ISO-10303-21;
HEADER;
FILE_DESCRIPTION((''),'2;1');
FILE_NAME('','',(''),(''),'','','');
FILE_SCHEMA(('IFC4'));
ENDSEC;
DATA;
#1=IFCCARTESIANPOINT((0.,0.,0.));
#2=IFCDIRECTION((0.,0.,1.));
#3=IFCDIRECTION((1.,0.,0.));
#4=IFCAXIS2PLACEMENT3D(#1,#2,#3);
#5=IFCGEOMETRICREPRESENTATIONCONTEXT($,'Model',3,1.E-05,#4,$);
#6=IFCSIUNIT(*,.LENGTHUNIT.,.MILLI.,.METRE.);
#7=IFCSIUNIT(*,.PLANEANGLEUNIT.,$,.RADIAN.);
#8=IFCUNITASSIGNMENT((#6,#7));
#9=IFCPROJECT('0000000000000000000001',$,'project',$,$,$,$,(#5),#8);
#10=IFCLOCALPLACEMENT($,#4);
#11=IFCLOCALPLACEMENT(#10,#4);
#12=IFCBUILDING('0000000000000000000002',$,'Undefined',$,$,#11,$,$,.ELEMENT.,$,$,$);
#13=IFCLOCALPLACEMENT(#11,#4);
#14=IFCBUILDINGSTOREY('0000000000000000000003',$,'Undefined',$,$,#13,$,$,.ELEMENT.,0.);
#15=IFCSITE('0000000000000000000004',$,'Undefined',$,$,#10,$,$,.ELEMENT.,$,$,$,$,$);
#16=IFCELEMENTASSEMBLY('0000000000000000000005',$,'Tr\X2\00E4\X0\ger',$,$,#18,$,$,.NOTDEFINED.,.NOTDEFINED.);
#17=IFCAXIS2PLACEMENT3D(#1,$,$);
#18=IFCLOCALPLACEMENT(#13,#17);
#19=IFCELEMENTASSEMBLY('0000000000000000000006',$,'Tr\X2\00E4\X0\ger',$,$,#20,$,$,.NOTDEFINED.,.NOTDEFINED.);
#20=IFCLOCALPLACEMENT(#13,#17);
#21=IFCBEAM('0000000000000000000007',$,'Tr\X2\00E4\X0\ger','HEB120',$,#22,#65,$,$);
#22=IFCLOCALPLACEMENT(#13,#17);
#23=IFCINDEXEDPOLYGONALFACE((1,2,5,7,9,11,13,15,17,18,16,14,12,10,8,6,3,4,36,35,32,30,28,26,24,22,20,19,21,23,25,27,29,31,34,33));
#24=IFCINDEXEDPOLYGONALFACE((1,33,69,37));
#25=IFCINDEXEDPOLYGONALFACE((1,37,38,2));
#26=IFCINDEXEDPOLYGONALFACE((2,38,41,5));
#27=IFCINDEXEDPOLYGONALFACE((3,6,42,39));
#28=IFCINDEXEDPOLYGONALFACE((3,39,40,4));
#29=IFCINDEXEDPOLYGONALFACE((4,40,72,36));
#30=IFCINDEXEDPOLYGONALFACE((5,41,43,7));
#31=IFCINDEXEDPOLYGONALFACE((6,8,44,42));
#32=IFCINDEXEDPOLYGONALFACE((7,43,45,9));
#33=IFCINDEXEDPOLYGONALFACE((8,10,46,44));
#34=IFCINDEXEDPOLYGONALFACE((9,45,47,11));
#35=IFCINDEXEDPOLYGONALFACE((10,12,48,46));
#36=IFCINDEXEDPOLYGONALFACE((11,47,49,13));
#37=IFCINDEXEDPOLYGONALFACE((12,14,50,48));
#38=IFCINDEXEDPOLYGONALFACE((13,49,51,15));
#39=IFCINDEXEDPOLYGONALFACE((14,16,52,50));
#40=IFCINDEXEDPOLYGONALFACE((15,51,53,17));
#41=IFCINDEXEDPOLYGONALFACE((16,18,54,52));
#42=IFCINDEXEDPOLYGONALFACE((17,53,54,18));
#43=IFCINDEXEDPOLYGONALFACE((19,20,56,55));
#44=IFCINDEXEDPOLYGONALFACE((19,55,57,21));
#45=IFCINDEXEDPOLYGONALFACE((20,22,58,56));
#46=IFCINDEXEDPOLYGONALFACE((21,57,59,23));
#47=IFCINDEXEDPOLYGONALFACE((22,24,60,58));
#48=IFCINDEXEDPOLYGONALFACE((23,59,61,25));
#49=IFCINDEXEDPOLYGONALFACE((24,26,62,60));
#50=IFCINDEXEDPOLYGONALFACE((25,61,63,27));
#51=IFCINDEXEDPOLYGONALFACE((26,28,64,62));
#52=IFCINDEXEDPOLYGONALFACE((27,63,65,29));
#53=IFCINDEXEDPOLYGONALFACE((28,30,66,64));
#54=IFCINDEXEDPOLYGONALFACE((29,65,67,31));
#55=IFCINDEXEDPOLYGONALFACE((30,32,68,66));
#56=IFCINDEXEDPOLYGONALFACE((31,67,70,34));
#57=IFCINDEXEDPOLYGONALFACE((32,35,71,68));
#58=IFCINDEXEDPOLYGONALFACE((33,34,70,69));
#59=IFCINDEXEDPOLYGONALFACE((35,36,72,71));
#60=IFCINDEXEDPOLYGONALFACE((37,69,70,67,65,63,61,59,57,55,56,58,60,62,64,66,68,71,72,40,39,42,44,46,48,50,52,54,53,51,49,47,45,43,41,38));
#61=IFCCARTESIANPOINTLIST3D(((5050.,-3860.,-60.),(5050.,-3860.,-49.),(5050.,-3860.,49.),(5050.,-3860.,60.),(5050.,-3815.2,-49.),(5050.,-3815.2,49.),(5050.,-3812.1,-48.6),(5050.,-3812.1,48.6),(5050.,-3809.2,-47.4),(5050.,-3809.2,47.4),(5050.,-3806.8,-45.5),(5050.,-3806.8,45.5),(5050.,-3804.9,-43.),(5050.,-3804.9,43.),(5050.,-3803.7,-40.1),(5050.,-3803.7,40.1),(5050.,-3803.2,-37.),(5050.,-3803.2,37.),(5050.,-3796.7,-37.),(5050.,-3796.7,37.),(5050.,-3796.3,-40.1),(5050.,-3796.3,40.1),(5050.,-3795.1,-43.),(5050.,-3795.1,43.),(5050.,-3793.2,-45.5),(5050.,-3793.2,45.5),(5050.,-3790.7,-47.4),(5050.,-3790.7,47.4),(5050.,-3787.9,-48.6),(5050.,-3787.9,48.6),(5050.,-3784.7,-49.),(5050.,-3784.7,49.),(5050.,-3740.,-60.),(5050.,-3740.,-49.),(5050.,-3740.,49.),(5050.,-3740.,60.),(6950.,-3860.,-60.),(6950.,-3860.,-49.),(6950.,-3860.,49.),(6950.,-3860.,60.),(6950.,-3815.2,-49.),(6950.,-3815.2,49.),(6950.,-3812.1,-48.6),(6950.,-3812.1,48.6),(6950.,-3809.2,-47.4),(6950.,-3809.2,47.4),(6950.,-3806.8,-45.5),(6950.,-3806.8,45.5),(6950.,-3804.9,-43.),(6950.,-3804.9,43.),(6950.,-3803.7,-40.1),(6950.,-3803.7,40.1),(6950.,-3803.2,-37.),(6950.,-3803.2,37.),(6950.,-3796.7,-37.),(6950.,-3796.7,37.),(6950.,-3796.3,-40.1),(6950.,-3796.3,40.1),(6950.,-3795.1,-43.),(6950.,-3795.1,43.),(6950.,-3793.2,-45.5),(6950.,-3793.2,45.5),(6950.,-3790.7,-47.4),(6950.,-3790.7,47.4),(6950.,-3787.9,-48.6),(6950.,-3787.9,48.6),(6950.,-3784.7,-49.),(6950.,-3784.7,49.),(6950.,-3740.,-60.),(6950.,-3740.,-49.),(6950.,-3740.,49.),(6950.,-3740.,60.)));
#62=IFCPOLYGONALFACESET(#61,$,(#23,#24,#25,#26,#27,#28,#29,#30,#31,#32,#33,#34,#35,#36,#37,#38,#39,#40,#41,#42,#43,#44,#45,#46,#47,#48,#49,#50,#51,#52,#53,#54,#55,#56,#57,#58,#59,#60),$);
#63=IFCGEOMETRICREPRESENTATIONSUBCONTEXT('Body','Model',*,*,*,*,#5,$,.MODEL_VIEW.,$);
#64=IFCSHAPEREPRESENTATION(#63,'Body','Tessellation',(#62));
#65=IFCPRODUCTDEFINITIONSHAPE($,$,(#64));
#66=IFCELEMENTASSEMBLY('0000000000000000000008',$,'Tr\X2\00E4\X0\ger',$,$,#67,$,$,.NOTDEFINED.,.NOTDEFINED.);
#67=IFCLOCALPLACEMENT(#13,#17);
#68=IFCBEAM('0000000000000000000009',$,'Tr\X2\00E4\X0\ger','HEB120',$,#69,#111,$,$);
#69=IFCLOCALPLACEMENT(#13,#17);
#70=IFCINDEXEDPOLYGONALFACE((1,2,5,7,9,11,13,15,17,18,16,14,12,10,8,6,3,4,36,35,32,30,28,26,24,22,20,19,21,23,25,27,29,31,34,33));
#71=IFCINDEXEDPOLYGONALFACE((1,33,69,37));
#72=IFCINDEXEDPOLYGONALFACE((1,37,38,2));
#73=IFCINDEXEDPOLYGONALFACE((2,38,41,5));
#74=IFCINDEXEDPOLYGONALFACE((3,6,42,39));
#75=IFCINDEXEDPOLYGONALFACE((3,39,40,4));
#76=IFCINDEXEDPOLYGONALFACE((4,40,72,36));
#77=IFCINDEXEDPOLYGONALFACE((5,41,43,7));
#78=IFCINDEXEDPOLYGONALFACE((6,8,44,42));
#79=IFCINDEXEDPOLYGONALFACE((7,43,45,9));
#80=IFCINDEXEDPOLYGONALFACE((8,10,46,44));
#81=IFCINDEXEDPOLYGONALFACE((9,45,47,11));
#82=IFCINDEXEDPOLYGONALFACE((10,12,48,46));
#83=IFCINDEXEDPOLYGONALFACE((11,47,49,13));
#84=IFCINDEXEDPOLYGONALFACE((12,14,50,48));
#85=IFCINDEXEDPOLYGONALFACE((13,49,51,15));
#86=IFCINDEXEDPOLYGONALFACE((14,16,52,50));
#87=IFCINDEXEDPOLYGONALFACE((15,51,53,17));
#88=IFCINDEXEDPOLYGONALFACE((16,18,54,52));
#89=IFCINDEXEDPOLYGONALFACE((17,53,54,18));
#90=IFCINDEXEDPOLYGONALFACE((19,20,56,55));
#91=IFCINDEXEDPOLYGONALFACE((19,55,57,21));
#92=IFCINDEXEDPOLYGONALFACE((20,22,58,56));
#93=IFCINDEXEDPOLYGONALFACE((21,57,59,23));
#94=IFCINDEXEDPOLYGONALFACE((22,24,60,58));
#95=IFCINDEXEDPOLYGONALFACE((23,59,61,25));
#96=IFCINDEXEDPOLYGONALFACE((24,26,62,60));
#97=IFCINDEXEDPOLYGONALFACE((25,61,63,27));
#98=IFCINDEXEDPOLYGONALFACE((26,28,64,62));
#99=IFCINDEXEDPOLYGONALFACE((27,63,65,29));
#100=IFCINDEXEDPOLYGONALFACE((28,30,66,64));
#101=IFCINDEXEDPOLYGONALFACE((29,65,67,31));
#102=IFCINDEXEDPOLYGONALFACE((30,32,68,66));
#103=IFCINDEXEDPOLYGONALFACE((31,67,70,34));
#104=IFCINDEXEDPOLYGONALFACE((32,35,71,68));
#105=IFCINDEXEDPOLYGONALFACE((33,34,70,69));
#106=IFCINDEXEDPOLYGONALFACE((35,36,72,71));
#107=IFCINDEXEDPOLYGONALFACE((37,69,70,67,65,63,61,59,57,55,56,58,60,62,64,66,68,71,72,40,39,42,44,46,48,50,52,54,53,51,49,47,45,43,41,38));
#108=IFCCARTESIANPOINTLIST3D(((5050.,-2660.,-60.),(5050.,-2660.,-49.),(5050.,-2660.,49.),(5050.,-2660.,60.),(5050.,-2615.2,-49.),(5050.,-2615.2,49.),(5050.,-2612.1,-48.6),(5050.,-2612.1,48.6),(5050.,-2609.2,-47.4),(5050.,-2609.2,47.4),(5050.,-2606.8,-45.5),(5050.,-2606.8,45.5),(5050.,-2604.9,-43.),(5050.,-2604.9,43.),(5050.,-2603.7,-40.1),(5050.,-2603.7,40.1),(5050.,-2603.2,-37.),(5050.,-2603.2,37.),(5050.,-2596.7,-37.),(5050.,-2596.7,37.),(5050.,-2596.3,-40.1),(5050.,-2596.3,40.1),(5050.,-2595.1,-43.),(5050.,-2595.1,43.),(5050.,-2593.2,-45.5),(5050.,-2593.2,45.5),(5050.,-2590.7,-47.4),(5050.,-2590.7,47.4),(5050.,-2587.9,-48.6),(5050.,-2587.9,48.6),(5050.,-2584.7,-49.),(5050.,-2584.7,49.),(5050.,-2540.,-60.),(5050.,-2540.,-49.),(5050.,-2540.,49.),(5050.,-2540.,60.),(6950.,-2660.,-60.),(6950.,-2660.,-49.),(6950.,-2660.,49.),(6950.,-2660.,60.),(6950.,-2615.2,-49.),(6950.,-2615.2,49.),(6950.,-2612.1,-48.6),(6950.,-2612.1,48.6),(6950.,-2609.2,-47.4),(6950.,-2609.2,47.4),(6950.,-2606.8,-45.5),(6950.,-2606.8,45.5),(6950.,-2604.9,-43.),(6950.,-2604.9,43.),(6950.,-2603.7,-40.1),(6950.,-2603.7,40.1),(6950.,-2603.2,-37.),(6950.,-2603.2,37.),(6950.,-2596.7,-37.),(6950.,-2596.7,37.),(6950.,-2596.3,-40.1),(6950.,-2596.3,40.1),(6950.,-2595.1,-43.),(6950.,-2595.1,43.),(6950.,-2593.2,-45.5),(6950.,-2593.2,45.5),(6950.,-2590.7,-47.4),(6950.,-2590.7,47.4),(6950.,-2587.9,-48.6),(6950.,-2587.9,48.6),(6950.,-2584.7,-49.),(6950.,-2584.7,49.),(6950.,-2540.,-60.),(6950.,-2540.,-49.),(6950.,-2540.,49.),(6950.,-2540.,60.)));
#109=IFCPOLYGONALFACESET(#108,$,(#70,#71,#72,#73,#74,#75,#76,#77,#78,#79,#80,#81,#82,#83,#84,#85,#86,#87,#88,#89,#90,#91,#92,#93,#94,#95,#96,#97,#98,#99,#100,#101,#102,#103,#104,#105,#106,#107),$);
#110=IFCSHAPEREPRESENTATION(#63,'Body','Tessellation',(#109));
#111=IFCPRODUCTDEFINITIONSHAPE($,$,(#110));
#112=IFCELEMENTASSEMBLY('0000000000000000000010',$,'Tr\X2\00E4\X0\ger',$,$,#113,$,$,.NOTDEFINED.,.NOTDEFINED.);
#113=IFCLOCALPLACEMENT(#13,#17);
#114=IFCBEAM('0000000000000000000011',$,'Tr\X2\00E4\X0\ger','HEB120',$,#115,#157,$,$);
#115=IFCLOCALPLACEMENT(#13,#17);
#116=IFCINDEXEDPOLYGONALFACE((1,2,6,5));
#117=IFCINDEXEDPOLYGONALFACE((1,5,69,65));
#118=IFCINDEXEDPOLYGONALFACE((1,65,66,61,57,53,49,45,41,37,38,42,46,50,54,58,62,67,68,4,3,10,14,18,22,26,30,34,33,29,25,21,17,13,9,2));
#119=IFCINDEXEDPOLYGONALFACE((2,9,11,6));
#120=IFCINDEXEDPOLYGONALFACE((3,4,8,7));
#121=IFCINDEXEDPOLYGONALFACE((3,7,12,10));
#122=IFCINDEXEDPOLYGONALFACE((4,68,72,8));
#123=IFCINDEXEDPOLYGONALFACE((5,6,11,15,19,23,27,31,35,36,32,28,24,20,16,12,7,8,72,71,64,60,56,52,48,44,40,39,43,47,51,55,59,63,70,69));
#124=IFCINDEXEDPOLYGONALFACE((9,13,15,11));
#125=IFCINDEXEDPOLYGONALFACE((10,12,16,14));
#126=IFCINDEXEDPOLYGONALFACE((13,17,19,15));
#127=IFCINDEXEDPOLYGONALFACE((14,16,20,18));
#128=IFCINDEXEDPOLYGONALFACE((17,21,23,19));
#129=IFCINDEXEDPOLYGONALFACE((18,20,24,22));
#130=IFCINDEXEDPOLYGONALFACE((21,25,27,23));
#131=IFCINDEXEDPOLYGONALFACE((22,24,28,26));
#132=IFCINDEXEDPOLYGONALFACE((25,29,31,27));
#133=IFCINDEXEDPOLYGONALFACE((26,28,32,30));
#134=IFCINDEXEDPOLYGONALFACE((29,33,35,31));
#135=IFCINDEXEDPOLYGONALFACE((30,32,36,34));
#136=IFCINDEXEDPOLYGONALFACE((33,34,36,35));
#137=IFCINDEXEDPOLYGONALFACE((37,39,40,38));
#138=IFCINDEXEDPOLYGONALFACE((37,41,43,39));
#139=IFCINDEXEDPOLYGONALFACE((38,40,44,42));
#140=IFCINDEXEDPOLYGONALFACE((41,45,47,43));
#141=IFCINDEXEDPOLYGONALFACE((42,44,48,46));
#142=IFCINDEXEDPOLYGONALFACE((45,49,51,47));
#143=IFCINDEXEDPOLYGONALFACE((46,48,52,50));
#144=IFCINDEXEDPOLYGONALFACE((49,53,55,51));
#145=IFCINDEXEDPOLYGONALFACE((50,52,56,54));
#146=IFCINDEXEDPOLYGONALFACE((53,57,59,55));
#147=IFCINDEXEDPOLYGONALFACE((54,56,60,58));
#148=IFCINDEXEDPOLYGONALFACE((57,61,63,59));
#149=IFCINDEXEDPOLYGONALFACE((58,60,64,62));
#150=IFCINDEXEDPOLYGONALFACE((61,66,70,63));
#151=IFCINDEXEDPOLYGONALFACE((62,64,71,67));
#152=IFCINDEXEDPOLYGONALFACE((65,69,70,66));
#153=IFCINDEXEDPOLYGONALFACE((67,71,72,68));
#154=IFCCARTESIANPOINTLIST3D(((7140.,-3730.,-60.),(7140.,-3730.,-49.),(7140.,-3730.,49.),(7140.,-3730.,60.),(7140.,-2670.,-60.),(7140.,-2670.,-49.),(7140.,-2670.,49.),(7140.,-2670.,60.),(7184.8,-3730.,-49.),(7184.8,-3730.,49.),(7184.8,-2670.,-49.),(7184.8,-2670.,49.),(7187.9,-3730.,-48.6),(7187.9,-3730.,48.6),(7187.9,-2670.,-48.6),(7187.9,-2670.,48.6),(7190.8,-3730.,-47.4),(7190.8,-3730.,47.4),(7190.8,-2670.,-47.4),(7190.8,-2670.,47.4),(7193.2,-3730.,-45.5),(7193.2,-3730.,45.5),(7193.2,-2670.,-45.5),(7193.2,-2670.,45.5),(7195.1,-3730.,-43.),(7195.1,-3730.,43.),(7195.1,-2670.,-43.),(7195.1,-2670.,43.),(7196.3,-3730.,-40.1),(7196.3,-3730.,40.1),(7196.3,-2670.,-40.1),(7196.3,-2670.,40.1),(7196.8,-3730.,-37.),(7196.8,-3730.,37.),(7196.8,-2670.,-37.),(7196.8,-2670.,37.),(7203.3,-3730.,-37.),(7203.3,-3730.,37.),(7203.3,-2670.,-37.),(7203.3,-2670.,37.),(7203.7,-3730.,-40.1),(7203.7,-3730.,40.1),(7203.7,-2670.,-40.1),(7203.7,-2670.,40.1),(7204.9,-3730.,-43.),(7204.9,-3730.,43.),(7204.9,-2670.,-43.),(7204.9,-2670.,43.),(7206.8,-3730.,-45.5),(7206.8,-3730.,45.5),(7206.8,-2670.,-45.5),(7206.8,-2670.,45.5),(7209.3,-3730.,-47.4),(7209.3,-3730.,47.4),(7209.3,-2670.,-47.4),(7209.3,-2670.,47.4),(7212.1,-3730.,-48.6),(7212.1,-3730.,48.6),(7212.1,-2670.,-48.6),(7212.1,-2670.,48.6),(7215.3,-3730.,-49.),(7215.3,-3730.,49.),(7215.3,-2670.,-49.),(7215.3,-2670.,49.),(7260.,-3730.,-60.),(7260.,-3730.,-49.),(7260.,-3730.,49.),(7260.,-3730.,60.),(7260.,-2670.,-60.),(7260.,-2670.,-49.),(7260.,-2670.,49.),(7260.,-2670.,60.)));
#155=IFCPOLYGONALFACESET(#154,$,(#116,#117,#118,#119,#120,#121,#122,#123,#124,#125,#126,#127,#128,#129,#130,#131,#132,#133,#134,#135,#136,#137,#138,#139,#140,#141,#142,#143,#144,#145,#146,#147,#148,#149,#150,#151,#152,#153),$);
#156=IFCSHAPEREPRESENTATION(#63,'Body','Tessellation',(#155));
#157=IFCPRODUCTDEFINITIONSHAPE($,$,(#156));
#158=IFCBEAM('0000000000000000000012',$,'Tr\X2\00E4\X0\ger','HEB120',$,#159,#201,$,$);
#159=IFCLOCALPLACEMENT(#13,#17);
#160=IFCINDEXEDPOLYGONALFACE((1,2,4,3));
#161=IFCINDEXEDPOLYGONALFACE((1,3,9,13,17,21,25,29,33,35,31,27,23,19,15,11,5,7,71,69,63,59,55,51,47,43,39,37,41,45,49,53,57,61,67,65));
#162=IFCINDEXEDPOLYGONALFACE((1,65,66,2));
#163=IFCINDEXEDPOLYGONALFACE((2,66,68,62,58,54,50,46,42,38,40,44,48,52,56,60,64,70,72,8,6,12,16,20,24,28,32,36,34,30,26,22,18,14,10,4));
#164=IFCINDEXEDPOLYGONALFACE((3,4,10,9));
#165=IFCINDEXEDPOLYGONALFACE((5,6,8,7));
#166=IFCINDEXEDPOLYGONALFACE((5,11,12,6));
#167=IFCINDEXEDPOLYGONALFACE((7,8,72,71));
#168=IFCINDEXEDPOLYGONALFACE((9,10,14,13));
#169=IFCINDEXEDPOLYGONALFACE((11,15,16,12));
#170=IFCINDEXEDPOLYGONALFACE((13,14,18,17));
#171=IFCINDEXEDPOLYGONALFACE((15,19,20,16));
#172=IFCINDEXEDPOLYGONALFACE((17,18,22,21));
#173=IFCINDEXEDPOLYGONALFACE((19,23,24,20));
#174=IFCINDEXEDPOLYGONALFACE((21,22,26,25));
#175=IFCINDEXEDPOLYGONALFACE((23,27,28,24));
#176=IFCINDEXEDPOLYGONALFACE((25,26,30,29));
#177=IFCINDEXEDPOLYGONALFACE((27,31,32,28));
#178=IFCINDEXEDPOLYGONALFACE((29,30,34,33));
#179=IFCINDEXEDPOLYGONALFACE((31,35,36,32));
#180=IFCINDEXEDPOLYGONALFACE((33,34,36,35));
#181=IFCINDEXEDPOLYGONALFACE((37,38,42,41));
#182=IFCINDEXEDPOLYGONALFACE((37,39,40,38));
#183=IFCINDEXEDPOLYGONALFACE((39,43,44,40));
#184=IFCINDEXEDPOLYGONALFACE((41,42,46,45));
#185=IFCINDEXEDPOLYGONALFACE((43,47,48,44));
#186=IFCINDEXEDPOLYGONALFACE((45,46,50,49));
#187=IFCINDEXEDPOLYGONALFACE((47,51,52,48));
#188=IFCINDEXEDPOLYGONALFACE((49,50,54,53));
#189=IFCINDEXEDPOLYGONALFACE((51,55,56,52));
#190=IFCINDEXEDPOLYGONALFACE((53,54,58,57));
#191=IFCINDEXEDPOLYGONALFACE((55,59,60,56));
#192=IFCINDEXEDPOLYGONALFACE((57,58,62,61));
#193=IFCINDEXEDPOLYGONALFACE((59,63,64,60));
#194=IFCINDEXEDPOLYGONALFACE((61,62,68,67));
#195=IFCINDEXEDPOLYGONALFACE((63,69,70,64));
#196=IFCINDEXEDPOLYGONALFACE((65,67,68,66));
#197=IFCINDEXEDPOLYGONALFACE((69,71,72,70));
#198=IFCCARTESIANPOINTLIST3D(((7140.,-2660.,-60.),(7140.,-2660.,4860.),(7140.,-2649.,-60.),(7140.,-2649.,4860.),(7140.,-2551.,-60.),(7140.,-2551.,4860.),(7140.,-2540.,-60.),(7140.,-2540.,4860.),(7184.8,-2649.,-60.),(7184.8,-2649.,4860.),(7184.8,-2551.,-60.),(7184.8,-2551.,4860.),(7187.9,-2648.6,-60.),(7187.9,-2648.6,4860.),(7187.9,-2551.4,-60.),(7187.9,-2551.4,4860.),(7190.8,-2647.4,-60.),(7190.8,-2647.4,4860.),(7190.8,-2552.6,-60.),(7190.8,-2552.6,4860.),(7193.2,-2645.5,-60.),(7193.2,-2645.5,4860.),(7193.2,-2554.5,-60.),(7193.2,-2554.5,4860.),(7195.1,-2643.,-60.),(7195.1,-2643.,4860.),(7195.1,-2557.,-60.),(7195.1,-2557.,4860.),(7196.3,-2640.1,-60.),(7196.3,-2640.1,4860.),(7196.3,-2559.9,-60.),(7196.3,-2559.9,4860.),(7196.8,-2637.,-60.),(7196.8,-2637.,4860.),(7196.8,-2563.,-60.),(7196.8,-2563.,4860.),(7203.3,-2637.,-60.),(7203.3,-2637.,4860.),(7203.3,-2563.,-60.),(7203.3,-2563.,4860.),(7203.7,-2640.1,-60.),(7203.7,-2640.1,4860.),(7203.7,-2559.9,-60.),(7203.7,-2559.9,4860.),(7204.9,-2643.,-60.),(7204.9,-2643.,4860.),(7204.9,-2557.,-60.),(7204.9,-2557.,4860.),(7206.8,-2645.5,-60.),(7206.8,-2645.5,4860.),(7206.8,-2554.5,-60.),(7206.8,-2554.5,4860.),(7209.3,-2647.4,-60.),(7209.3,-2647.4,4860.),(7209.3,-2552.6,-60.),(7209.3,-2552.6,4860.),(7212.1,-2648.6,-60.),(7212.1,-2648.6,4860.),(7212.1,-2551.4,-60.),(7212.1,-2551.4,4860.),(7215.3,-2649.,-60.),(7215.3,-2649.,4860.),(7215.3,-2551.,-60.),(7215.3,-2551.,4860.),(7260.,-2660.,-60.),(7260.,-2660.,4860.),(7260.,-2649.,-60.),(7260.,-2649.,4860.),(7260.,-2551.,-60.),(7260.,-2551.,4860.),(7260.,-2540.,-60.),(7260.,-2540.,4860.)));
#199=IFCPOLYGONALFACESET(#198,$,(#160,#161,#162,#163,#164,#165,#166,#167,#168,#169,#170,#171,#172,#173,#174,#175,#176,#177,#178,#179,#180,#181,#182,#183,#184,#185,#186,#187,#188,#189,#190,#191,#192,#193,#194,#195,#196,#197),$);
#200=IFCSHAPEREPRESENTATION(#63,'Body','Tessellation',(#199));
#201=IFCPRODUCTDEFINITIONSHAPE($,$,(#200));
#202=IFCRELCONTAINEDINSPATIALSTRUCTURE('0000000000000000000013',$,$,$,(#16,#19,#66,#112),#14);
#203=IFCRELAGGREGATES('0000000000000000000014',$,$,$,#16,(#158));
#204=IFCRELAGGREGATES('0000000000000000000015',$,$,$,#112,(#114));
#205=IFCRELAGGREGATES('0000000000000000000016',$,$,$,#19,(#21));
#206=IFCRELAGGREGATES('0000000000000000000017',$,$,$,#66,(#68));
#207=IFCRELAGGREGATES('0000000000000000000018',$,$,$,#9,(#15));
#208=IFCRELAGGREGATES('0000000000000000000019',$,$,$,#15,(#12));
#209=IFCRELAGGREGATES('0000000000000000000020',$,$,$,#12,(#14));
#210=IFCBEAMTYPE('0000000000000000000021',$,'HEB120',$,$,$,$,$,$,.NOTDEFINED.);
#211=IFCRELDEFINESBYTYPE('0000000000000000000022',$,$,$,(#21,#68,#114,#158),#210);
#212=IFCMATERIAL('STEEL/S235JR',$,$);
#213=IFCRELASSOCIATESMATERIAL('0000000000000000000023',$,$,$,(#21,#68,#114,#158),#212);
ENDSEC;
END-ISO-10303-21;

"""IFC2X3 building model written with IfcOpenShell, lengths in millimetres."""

from ifc_helpers import new_model, si_unit, frame, origin_with_axes, origin_2d_with_axis, place, context, subcontext, project, spatial, i_section, extrude, clip, halfspace, material, type_object, element, aggregate, save


model = new_model("IFC2X3")

# Units and contexts
model_context = context("Model", 3, precision=1e-05, world=origin_with_axes())
body_context = subcontext(model_context, "Body", "Model", "MODEL_VIEW")
ifc_project = project(units=[si_unit("LENGTHUNIT", "METRE", prefix="MILLI"), si_unit("PLANEANGLEUNIT", "RADIAN")], contexts=[model_context])

# Site, building, storey
site_placement = place(None, origin_with_axes())
site = spatial("IfcSite", under=ifc_project, at=site_placement, Name="Undefined", CompositionType="ELEMENT")
building_placement = place(site_placement, origin_with_axes())
building = spatial("IfcBuilding", under=site, at=building_placement, Name="Undefined", CompositionType="ELEMENT")
storey_placement = place(building_placement, origin_with_axes())
storey = spatial("IfcBuildingStorey", under=building, at=storey_placement, Name="Undefined", CompositionType="ELEMENT", Elevation=0.0)

# Element assemblies, beams
ifc_material_1 = material(Name="STEEL/S235JR")
beam_type = type_object("IfcBeamType", Name="HEB120", PredefinedType="NOTDEFINED")
assembly_1_placement = place(storey_placement, origin_with_axes())
assembly_1 = element("IfcElementAssembly", 1, at=assembly_1_placement, inside=storey, Name="Träger", AssemblyPlace="NOTDEFINED", PredefinedType="NOTDEFINED")
assembly_2_placement = place(storey_placement, origin_with_axes())
assembly_2 = element("IfcElementAssembly", 2, at=assembly_2_placement, inside=storey, Name="Träger", AssemblyPlace="NOTDEFINED", PredefinedType="NOTDEFINED")
beam_1_placement = place(assembly_2_placement, frame((6950.0, -3800.0, 0.0), z_axis=(0.0, 0.0, 1.0), x_axis=(-1.0, 0.0, 0.0)))
beam_1 = element("IfcBeam", 3, at=beam_1_placement, type_object=beam_type, material=ifc_material_1, Name="Träger", Description="HEB120", context=body_context, shape_type="Clipping", body=[
    clip(clip(extrude(i_section(OverallWidth=120.0, OverallDepth=120.0, WebThickness=6.5, FlangeThickness=11.0, FilletRadius=12.0, at=origin_2d_with_axis()), frame((1910.0, 0.0, 0.0), z_axis=(-1.0, 0.0, 0.0), x_axis=(0.0, -1.0, 0.0)), (0.0, 0.0, 1.0), 1910.0), halfspace(frame((1900.0, 0.0, -60.0), z_axis=(-1.0, 0.0, 0.0), x_axis=(0.0, 1.0, 0.0)), True)), halfspace(frame((0.0, 0.0, -60.0), z_axis=(1.0, 0.0, 0.0), x_axis=(0.0, -1.0, 0.0)), True)),
])
assembly_3_placement = place(storey_placement, origin_with_axes())
assembly_3 = element("IfcElementAssembly", 4, at=assembly_3_placement, inside=storey, Name="Träger", AssemblyPlace="NOTDEFINED", PredefinedType="NOTDEFINED")
beam_2_placement = place(assembly_3_placement, frame((6950.0, -2600.0, 0.0), z_axis=(0.0, 0.0, 1.0), x_axis=(-1.0, 0.0, 0.0)))
beam_2 = element("IfcBeam", 5, at=beam_2_placement, type_object=beam_type, material=ifc_material_1, Name="Träger", Description="HEB120", context=body_context, shape_type="Clipping", body=[
    clip(clip(extrude(i_section(OverallWidth=120.0, OverallDepth=120.0, WebThickness=6.5, FlangeThickness=11.0, FilletRadius=12.0, at=origin_2d_with_axis()), frame((1910.0, 0.0, 0.0), z_axis=(-1.0, 0.0, 0.0), x_axis=(0.0, -1.0, 0.0)), (0.0, 0.0, 1.0), 1910.0), halfspace(frame((1900.0, 0.0, -60.0), z_axis=(-1.0, 0.0, 0.0), x_axis=(0.0, 1.0, 0.0)), True)), halfspace(frame((0.0, 0.0, -60.0), z_axis=(1.0, 0.0, 0.0), x_axis=(0.0, -1.0, 0.0)), True)),
])
assembly_4_placement = place(storey_placement, origin_with_axes())
assembly_4 = element("IfcElementAssembly", 6, at=assembly_4_placement, inside=storey, Name="Träger", AssemblyPlace="NOTDEFINED", PredefinedType="NOTDEFINED")
beam_3_placement = place(assembly_4_placement, frame((7200.0, -2670.0, 0.0), z_axis=(0.0, 0.0, 1.0), x_axis=(0.0, -1.0, 0.0)))
beam_3 = element("IfcBeam", 7, at=beam_3_placement, type_object=beam_type, material=ifc_material_1, Name="Träger", Description="HEB120", context=body_context, shape_type="Clipping", body=[
    clip(clip(extrude(i_section(OverallWidth=120.0, OverallDepth=120.0, WebThickness=6.5, FlangeThickness=11.0, FilletRadius=12.0, at=origin_2d_with_axis()), frame((1060.0, 0.0, 0.0), z_axis=(-1.0, 0.0, 0.0), x_axis=(0.0, -1.0, 0.0)), (0.0, 0.0, 1.0), 1060.0), halfspace(frame((1060.0, 0.0, -60.0), z_axis=(-1.0, 0.0, 0.0), x_axis=(0.0, 1.0, 0.0)), True)), halfspace(frame((0.0, 0.0, -60.0), z_axis=(1.0, 0.0, 0.0), x_axis=(0.0, -1.0, 0.0)), True)),
])

# Beam
beam_4_placement = place(assembly_1_placement, frame((7200.0, -2600.0, -60.0), z_axis=(0.0, 1.0, 0.0), x_axis=(0.0, 0.0, 1.0)))
beam_4 = element("IfcBeam", 8, at=beam_4_placement, type_object=beam_type, material=ifc_material_1, Name="Träger", Description="HEB120", context=body_context, shape_type="SweptSolid", body=[
    extrude(i_section(OverallWidth=120.0, OverallDepth=120.0, WebThickness=6.5, FlangeThickness=11.0, FilletRadius=12.0, at=origin_2d_with_axis()), frame((4920.0, 0.0, 0.0), z_axis=(-1.0, 0.0, 0.0), x_axis=(0.0, -1.0, 0.0)), (0.0, 0.0, 1.0), 4920.0),
])

aggregate(assembly_1, [beam_4])
aggregate(assembly_4, [beam_3])

aggregate(assembly_2, [beam_1])
aggregate(assembly_3, [beam_2])

save(model, "model.ifc")
